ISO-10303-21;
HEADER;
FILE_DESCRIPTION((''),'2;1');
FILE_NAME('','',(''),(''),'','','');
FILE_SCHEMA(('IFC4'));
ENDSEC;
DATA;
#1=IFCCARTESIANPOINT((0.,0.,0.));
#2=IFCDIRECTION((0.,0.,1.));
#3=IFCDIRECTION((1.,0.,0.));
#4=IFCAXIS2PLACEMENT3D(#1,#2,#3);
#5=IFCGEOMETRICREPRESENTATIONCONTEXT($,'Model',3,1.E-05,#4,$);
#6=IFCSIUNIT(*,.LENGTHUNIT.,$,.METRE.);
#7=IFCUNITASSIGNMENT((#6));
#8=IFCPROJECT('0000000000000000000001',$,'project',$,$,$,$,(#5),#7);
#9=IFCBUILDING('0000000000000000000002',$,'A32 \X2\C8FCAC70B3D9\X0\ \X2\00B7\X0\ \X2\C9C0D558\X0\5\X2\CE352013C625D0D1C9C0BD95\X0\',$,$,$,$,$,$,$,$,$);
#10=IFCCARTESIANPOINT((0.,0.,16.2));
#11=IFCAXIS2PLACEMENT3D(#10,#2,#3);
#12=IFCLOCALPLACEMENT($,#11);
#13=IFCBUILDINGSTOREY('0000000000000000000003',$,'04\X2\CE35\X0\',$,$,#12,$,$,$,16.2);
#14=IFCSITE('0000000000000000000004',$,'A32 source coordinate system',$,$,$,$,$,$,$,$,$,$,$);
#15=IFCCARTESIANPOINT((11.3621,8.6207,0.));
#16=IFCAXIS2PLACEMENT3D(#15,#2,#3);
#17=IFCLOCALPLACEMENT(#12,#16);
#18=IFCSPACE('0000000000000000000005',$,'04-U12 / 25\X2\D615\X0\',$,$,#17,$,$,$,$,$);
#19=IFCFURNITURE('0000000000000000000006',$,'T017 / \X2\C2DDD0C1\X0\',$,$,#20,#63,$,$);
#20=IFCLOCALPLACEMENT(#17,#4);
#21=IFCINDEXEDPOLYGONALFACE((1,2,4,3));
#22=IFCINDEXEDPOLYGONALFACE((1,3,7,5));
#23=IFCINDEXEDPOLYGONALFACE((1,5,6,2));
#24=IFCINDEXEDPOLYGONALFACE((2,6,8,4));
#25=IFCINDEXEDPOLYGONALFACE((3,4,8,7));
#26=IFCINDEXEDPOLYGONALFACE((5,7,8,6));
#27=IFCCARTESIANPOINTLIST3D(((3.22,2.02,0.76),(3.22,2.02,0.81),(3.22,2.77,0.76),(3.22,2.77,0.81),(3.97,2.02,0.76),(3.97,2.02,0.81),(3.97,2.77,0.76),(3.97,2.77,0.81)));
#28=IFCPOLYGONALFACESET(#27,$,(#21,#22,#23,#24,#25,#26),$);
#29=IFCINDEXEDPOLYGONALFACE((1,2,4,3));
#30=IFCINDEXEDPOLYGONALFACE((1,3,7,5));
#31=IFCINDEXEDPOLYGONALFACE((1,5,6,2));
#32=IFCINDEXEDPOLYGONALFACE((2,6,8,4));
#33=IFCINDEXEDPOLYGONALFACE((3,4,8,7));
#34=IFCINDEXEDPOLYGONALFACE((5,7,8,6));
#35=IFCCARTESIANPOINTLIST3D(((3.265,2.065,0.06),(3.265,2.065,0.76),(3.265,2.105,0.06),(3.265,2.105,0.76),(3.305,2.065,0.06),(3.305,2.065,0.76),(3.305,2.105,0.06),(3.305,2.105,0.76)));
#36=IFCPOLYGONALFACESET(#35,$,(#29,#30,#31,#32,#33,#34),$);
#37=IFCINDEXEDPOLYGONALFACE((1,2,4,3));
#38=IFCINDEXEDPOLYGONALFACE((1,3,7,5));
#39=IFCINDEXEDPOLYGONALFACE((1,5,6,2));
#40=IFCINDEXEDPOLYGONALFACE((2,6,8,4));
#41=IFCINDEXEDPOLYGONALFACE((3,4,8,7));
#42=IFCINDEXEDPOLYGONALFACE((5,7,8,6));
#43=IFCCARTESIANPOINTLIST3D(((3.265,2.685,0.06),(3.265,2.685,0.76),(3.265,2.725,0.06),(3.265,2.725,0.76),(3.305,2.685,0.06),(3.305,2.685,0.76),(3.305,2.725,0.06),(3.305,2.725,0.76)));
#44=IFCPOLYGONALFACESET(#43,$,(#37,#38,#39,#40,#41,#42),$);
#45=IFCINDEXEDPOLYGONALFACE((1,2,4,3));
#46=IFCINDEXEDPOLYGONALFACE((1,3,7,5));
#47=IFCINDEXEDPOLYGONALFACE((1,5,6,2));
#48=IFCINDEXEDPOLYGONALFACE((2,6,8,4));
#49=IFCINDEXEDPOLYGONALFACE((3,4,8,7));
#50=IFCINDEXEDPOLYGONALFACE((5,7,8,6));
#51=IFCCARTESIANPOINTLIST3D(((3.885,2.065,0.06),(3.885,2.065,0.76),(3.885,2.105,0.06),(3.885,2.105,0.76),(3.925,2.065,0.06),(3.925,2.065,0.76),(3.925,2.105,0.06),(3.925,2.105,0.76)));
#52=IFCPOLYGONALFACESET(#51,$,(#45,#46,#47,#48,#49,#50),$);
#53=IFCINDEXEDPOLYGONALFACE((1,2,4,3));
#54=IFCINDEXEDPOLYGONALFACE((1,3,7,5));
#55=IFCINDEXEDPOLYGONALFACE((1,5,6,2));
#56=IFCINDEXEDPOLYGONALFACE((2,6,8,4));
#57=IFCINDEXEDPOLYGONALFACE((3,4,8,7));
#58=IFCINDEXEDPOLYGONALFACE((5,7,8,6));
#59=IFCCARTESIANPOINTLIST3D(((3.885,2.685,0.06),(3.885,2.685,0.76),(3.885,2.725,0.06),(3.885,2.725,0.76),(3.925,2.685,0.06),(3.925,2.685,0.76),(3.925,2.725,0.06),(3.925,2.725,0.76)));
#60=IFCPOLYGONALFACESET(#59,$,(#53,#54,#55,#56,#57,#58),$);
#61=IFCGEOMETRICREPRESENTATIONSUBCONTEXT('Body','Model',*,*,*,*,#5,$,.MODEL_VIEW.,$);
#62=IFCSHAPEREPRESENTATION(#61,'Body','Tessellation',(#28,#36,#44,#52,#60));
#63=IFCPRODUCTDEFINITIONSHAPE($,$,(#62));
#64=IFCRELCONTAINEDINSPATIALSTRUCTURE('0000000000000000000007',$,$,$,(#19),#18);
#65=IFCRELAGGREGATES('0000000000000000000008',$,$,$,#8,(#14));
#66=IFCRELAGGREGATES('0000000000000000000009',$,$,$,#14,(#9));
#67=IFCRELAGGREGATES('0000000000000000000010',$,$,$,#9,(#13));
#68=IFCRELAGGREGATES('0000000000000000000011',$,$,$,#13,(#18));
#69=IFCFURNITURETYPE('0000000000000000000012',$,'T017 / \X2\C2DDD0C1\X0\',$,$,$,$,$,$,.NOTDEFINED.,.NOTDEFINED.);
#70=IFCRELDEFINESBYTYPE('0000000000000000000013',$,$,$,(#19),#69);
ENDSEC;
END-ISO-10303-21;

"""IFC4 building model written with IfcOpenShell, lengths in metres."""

from ifc_helpers import new_model, si_unit, frame, origin, origin_with_axes, place, context, subcontext, project, spatial, polyline, outline, extrude, source, transform, mapped, type_object, type_shapes, element, save


model = new_model("IFC4")

# Units and contexts
model_context = context("Model", 3, precision=1e-05, world=origin_with_axes())
body_context = subcontext(model_context, "Body", "Model", "MODEL_VIEW")
ifc_project = project(units=[si_unit("LENGTHUNIT", "METRE")], contexts=[model_context])

# Site, building, storey
site = spatial("IfcSite", under=ifc_project, Name="A32 source coordinate system")
building = spatial("IfcBuilding", under=site, Name="A32 주거동 · 지하5층–옥탑지붕")
storey_placement = place(None, frame((0.0, 0.0, 16.2), z_axis=(0.0, 0.0, 1.0), x_axis=(1.0, 0.0, 0.0)))
storey = spatial("IfcBuildingStorey", under=building, at=storey_placement, Name="04층", Elevation=16.2)

# Shared definitions
space_1_placement = place(storey_placement, frame((11.3621, 8.6207, 0.0), z_axis=(0.0, 0.0, 1.0), x_axis=(1.0, 0.0, 0.0)))

# Shared definitions
space_1 = spatial("IfcSpace", under=storey, at=space_1_placement, Name="04-U12 / 25형")

# Furniture
furniture_type_1 = type_object("IfcFurnitureType", Name="T017 / 식탁", AssemblyPlace="NOTDEFINED", PredefinedType="NOTDEFINED")
shared_shape_1 = source(origin(), body_context, "Body", "SweptSolid", [
    extrude(outline(polyline([(3.97, 2.02), (3.22, 2.02), (3.22, 2.77), (3.97, 2.77), (3.97, 2.02)])), frame((0.0, 0.0, 0.76)), (0.0, 0.0, 1.0), 0.05),
    extrude(outline(polyline([(3.265, 2.065), (3.265, 2.105), (3.305, 2.105), (3.305, 2.065), (3.265, 2.065)])), frame((0.0, 0.0, 0.06)), (0.0, 0.0, 1.0), 0.7),
    extrude(outline(polyline([(3.265, 2.685), (3.265, 2.725), (3.305, 2.725), (3.305, 2.685), (3.265, 2.685)])), frame((0.0, 0.0, 0.06)), (0.0, 0.0, 1.0), 0.7),
    extrude(outline(polyline([(3.885, 2.065), (3.885, 2.105), (3.925, 2.105), (3.925, 2.065), (3.885, 2.065)])), frame((0.0, 0.0, 0.06)), (0.0, 0.0, 1.0), 0.7),
    extrude(outline(polyline([(3.885, 2.685), (3.885, 2.725), (3.925, 2.725), (3.925, 2.685), (3.885, 2.685)])), frame((0.0, 0.0, 0.06)), (0.0, 0.0, 1.0), 0.7),
])
type_shapes(furniture_type_1, [shared_shape_1])
furniture_1_placement = place(space_1_placement, origin_with_axes())
element("IfcFurniture", 1, at=furniture_1_placement, inside=space_1, type_object=furniture_type_1, Name="T017 / 식탁", context=body_context, shape_type="MappedRepresentation", body=[
    mapped(shared_shape_1, transform((0.0, 0.0, 0.0), scale=1.0)),
])

save(model, "model.ifc")
